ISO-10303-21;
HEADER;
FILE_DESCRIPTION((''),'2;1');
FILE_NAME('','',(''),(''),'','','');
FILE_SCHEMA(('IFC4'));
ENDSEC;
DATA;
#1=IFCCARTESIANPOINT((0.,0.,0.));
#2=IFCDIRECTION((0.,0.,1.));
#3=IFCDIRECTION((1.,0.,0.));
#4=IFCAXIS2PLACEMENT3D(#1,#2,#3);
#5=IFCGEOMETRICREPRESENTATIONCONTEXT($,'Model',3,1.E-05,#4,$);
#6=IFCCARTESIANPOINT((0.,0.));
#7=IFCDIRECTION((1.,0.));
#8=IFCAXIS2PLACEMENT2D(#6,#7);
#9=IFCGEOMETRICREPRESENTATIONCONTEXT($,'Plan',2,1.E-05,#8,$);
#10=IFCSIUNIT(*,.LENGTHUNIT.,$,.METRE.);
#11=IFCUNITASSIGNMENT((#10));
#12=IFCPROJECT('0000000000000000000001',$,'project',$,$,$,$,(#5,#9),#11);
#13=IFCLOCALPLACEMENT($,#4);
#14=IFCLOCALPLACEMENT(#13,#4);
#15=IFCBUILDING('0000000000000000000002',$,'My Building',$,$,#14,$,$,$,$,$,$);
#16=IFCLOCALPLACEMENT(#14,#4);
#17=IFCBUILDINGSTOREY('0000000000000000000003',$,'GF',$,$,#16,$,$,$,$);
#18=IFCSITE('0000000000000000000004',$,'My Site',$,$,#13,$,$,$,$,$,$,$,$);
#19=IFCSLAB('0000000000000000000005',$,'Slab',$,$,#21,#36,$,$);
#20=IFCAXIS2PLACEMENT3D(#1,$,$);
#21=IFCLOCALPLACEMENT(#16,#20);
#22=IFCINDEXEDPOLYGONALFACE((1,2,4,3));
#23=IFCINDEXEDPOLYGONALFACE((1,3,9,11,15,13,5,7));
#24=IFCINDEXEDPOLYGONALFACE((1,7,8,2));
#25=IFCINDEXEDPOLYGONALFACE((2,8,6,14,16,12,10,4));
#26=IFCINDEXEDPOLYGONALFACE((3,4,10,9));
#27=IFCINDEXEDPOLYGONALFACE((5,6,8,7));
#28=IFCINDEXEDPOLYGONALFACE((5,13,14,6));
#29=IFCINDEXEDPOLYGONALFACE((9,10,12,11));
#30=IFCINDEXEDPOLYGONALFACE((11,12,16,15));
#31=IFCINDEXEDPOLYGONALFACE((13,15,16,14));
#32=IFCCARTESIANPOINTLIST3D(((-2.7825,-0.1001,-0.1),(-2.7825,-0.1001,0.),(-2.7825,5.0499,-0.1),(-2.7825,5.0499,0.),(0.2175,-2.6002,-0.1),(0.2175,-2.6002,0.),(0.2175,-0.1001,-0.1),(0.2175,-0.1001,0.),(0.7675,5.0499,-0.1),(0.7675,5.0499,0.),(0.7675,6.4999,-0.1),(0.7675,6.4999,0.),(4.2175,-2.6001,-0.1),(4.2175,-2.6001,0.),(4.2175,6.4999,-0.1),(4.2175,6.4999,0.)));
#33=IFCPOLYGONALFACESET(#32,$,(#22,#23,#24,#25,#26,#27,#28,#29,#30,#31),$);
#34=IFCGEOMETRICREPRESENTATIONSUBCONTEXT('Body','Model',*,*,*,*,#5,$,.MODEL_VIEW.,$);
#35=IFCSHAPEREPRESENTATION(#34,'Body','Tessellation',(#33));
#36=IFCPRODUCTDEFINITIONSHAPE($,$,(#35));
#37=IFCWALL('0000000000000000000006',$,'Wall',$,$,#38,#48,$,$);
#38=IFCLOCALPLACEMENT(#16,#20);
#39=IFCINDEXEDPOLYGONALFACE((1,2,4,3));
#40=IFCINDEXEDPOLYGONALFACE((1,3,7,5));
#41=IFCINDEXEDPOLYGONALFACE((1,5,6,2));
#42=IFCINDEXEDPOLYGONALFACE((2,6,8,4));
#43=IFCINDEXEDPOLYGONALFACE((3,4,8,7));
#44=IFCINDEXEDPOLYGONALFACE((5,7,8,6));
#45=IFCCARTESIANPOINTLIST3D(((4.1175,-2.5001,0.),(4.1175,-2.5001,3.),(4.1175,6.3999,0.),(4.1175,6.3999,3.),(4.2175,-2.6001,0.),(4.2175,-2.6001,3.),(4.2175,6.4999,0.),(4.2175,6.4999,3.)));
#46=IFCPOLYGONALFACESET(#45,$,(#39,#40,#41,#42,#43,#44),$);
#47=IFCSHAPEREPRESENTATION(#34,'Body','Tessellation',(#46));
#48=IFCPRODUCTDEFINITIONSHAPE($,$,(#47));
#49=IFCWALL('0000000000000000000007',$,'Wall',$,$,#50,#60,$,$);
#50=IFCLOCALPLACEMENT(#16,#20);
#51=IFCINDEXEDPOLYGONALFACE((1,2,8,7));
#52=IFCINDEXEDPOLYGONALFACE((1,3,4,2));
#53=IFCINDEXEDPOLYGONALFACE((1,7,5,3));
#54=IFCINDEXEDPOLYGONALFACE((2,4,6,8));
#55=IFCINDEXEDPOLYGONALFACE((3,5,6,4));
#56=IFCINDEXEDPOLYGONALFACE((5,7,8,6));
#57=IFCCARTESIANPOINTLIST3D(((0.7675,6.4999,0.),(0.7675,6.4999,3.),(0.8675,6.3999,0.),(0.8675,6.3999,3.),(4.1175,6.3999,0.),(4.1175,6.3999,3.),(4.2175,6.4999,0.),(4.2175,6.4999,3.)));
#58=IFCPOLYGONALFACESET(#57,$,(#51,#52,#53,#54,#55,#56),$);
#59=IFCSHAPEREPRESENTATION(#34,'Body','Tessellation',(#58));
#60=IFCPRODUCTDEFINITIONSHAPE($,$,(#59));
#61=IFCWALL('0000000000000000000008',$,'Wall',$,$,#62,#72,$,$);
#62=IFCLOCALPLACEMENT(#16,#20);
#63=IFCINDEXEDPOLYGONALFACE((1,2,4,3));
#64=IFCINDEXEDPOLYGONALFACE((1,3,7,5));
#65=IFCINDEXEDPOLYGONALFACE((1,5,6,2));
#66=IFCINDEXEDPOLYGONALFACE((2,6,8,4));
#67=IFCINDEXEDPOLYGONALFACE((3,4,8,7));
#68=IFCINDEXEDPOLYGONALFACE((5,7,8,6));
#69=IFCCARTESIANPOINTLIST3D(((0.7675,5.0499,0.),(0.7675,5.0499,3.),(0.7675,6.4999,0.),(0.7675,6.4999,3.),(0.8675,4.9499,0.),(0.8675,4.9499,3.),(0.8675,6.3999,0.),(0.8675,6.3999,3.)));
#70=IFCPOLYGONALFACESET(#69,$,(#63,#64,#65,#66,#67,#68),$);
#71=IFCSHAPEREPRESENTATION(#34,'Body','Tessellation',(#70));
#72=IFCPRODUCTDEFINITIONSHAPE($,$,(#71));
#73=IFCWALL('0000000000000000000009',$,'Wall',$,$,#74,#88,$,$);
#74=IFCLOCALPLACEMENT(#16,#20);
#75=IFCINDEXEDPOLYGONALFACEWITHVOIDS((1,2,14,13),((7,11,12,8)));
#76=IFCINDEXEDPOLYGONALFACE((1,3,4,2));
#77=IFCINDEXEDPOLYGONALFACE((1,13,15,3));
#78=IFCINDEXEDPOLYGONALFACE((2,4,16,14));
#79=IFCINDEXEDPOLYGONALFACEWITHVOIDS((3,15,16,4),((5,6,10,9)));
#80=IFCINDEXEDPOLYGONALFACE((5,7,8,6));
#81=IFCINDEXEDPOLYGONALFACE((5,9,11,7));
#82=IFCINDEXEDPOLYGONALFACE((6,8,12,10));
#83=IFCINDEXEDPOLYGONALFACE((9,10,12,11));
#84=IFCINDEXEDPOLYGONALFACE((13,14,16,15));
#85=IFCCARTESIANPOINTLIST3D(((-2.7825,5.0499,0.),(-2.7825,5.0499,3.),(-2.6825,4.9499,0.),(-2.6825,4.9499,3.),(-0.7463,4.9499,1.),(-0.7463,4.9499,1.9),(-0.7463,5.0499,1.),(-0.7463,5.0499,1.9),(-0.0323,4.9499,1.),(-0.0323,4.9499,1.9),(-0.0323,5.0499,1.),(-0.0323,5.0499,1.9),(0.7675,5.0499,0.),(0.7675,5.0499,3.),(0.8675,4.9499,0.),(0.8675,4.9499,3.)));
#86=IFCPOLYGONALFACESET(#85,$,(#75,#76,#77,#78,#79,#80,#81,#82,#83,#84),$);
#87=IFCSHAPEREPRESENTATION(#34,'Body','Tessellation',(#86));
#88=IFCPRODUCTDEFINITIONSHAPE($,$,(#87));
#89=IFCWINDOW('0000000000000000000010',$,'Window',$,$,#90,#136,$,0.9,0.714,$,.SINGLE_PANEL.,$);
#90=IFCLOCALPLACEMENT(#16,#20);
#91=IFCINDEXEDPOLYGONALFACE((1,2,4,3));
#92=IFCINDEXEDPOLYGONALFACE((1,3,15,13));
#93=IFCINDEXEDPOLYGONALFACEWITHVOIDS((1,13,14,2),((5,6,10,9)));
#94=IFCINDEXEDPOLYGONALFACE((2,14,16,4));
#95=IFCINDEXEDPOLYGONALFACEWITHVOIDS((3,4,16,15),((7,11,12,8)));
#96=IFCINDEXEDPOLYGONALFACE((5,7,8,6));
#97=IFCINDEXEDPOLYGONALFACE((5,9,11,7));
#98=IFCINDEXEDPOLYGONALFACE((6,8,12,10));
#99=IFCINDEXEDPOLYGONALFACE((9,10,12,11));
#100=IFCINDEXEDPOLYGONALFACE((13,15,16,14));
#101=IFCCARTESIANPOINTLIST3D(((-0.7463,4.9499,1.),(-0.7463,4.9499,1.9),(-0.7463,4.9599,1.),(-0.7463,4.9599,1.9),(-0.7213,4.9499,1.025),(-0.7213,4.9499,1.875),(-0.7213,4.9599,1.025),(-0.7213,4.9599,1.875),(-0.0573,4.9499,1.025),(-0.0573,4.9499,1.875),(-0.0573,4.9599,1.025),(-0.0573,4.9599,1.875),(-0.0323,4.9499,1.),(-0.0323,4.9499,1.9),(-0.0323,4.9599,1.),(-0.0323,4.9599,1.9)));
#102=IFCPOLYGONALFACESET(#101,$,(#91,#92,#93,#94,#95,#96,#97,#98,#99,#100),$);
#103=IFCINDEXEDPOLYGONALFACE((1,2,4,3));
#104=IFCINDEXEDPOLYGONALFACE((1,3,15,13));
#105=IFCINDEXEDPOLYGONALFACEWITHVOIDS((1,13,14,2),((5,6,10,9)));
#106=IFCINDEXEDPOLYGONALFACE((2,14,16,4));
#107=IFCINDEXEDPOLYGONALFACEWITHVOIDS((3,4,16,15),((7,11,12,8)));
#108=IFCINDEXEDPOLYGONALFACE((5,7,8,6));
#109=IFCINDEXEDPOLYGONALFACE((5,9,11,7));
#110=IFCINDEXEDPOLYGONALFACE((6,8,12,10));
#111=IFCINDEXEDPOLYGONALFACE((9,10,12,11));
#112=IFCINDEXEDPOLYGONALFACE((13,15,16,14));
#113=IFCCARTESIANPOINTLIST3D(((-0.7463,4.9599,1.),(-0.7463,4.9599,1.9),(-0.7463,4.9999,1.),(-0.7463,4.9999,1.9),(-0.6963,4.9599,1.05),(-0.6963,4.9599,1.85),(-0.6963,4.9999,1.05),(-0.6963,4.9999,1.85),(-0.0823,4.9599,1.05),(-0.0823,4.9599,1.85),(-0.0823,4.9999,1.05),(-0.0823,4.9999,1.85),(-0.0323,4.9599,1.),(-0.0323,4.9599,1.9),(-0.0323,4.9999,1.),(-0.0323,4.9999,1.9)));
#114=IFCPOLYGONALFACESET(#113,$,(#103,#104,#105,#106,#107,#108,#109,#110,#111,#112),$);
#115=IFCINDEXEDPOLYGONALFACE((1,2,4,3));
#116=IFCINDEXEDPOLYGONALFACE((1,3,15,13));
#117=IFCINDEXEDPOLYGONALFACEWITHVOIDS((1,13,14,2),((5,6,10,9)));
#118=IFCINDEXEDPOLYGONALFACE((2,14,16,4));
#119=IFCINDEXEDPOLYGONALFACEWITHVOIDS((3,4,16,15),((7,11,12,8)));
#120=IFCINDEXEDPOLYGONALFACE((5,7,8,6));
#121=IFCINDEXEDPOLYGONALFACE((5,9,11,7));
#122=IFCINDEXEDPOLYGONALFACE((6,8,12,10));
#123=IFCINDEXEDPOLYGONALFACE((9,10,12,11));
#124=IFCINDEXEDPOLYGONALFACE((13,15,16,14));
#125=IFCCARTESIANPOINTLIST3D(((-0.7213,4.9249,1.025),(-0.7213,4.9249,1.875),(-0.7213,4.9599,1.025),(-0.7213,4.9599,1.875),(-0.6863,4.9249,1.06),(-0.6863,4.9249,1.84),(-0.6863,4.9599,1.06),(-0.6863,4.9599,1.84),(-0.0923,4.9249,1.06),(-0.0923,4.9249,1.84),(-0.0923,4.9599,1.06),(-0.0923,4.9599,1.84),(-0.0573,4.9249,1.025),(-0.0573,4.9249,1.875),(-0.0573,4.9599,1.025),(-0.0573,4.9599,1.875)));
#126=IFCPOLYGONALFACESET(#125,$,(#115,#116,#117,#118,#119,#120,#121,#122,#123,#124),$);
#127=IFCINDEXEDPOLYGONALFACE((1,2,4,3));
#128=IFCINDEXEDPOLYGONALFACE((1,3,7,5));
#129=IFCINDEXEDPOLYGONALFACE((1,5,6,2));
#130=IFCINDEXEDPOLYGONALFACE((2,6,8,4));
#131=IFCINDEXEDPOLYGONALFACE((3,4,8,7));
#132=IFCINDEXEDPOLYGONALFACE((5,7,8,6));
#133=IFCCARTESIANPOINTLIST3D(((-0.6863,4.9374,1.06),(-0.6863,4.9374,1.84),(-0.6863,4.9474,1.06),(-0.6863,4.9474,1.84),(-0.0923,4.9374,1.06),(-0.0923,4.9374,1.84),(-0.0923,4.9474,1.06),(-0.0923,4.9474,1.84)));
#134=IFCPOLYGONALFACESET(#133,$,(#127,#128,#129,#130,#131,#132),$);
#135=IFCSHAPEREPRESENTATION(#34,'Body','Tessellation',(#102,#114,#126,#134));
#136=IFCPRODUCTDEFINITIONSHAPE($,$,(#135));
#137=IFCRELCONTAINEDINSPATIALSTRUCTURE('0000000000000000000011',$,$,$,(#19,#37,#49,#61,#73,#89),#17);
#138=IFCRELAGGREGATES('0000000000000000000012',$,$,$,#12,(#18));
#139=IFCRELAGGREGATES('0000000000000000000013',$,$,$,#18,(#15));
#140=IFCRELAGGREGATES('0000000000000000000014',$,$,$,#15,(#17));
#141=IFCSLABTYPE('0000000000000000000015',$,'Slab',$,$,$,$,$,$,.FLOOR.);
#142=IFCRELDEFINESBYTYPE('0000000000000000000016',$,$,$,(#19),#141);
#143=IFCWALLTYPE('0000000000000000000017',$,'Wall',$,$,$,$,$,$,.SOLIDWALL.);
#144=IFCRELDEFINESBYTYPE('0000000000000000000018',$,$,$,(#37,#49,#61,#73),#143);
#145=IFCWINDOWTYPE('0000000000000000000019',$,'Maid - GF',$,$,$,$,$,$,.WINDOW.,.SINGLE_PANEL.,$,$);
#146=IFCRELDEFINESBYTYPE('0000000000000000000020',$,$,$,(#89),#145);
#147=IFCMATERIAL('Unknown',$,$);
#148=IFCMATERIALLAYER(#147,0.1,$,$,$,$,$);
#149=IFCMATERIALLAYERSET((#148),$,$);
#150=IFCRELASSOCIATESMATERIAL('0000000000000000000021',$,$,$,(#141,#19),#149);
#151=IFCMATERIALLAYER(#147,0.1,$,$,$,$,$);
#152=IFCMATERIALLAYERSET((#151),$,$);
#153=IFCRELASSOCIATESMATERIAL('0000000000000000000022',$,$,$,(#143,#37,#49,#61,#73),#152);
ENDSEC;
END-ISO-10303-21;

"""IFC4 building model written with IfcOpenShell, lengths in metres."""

from ifc_helpers import new_model, entity, si_unit, frame, origin_with_axes, origin_2d_with_axis, place, context, subcontext, project, spatial, line, indexed_curve, outline, extrude, shape, source, transform, mapped, material, layer, layer_set, layer_usage, type_object, type_shapes, element, fill, save


model = new_model("IFC4")

# Units and contexts
model_context = context("Model", 3, precision=1e-05, world=origin_with_axes())
plan_context = context("Plan", 2, precision=1e-05, world=origin_2d_with_axis())
body_context_1 = subcontext(model_context, "Body", "Model", "MODEL_VIEW")
body_context_2 = subcontext(plan_context, "Body", "Plan", "PLAN_VIEW")
ifc_project = project(units=[si_unit("LENGTHUNIT", "METRE")], contexts=[model_context, plan_context])

# Site, building, storey
site_placement = place(None, origin_with_axes())
site = spatial("IfcSite", under=ifc_project, at=site_placement, Name="My Site")
building_placement = place(site_placement, origin_with_axes())
building = spatial("IfcBuilding", under=site, at=building_placement, Name="My Building")
storey_placement = place(building_placement, origin_with_axes())
storey = spatial("IfcBuildingStorey", under=building, at=storey_placement, Name="GF")

# Slab
ifc_material = material(Name="Unknown")
ifc_layer_1 = layer(ifc_material, 0.1)
ifc_layer_set_1 = layer_set([ifc_layer_1])
ifc_layer_usage_1 = layer_usage(ifc_layer_set_1, "AXIS3", "POSITIVE", -0.1)
slab_type = type_object("IfcSlabType", Name="Slab", PredefinedType="FLOOR", material=ifc_layer_set_1)
slab_placement = place(storey_placement, frame((4.2175, -2.6001, 0.0), z_axis=(0.0, 0.0, 1.0), x_axis=(1.0, 0.0, 0.0)))
element("IfcSlab", 1, at=slab_placement, inside=storey, type_object=slab_type, material=ifc_layer_usage_1, Name="Slab", context=body_context_1, shape_type="SweptSolid", body=[
    extrude(outline(indexed_curve([(0.0, 0.0), (0.0, 9.1), (-3.45, 9.1), (-3.45, 7.6499), (-7.0, 7.6499), (-7.0, 2.5), (-4.0, 2.5), (-4.0, -0.0001), (0.0, 0.0)])), frame((0.0, 0.0, -0.1), z_axis=(0.0, 0.0, 1.0), x_axis=(1.0, 0.0, 0.0)), (0.0, 0.0, 1.0), 0.1),
])

# Shared definitions
ifc_layer_2 = layer(ifc_material, 0.1)
ifc_layer_set_2 = layer_set([ifc_layer_2])
wall_type = type_object("IfcWallType", Name="Wall", PredefinedType="SOLIDWALL", material=ifc_layer_set_2)

# Walls
ifc_layer_usage_2 = layer_usage(ifc_layer_set_2, "AXIS2", "POSITIVE", 0.0)
wall_1_placement = place(storey_placement, frame((4.2175, -2.6001, 0.0), z_axis=(0.0, 0.0, 1.0), x_axis=(0.0, 1.0, 0.0)))
element("IfcWall", 2, at=wall_1_placement, inside=storey, type_object=wall_type, material=ifc_layer_usage_2, Name="Wall", context=body_context_1, shape_type="SweptSolid", body=[
    extrude(outline(indexed_curve([(0.0, 0.0), (0.1, 0.1), (9.0, 0.1), (9.1, 0.0)], segments=[line(1, 2, 3, 4, 1)])), origin_with_axes(), (0.0, 0.0, 1.0), 3.0),
])
ifc_layer_usage_3 = layer_usage(ifc_layer_set_2, "AXIS2", "POSITIVE", 0.0)
wall_2_placement = place(storey_placement, frame((4.2175, 6.4999, 0.0), z_axis=(0.0, 0.0, 1.0), x_axis=(-1.0, 0.0, 0.0)))
element("IfcWall", 3, at=wall_2_placement, inside=storey, type_object=wall_type, material=ifc_layer_usage_3, Name="Wall", context=body_context_1, shape_type="SweptSolid", body=[
    extrude(outline(indexed_curve([(0.0, 0.0), (0.1, 0.1), (3.35, 0.1), (3.45, 0.0)], segments=[line(1, 2, 3, 4, 1)])), origin_with_axes(), (0.0, 0.0, 1.0), 3.0),
])
ifc_layer_usage_4 = layer_usage(ifc_layer_set_2, "AXIS2", "POSITIVE", 0.0)
wall_3_placement = place(storey_placement, frame((0.7675, 6.4999, 0.0), z_axis=(0.0, 0.0, 1.0), x_axis=(0.0, -1.0, 0.0)))
element("IfcWall", 4, at=wall_3_placement, inside=storey, type_object=wall_type, material=ifc_layer_usage_4, Name="Wall", context=body_context_1, shape_type="SweptSolid", body=[
    extrude(outline(indexed_curve([(0.0, 0.0), (0.1, 0.1), (1.55, 0.1), (1.45, 0.0)], segments=[line(1, 2, 3, 4, 1)])), origin_with_axes(), (0.0, 0.0, 1.0), 3.0),
])

# Wall, opening, window
ifc_layer_usage_5 = layer_usage(ifc_layer_set_2, "AXIS2", "POSITIVE", 0.0)
wall_4_placement = place(storey_placement, frame((0.7675, 5.0499, 0.0), z_axis=(0.0, 0.0, 1.0), x_axis=(-1.0, 0.0, 0.0)))
wall_4 = element("IfcWall", 5, at=wall_4_placement, inside=storey, type_object=wall_type, material=ifc_layer_usage_5, Name="Wall", context=body_context_1, shape_type="SweptSolid", body=[
    extrude(outline(indexed_curve([(0.0, 0.0), (-0.1, 0.1), (3.45, 0.1), (3.55, 0.0)], segments=[line(1, 2, 3, 4, 1)])), origin_with_axes(), (0.0, 0.0, 1.0), 3.0),
])
shared_shape_1 = source(origin_with_axes(), body_context_1, "Body", "SweptSolid", [
    extrude(outline(indexed_curve([(0.0, 0.0), (0.714, 0.0), (0.714, 0.9), (0.0, 0.9)], segments=[line(1, 2, 3, 4, 1)])), frame((0.0, -0.6, 0.0), z_axis=(0.0, -1.0, 0.0), x_axis=(1.0, 0.0, 0.0)), (0.0, 0.0, -1.0), 1.2),
])
opening_1_placement = place(wall_4_placement, frame((0.7998, 0.0, 1.0), z_axis=(0.0, 0.0, 1.0), x_axis=(1.0, 0.0, 0.0)))
opening_1 = element("IfcOpeningElement", 6, at=opening_1_placement, cuts=wall_4, PredefinedType="OPENING", context=body_context_1, shape_type="MappedRepresentation", body=[
    mapped(shared_shape_1, transform((0.0, 0.0, 0.0), x_axis=(1.0, 0.0, 0.0), y_axis=(0.0, 1.0, 0.0), z_axis=(0.0, 0.0, 1.0), scale=1.0)),
])
window_type_1 = type_object("IfcWindowType", Name="Maid - GF", PartitioningType="SINGLE_PANEL", PredefinedType="WINDOW")
shared_shape_2 = source(origin_with_axes(), body_context_1, "Body", "SweptSolid", [
    extrude(outline(indexed_curve([(0.0, 0.0), (0.714, 0.0), (0.714, 0.9), (0.0, 0.9)], segments=[line(1, 2, 3, 4, 1)]), holes=[indexed_curve([(0.025, 0.025), (0.689, 0.025), (0.689, 0.875), (0.025, 0.875)], segments=[line(1, 2, 3, 4, 1)])]), frame((0.0, 0.09, 0.0), z_axis=(0.0, -1.0, 0.0), x_axis=(1.0, 0.0, 0.0)), (0.0, 0.0, -1.0), 0.01),
    extrude(outline(indexed_curve([(0.0, 0.0), (0.714, 0.0), (0.714, 0.9), (0.0, 0.9)], segments=[line(1, 2, 3, 4, 1)]), holes=[indexed_curve([(0.05, 0.05), (0.664, 0.05), (0.664, 0.85), (0.05, 0.85)], segments=[line(1, 2, 3, 4, 1)])]), frame((0.0, 0.05, 0.0), z_axis=(0.0, -1.0, 0.0), x_axis=(1.0, 0.0, 0.0)), (0.0, 0.0, -1.0), 0.04),
    extrude(outline(indexed_curve([(0.0, 0.0), (0.664, 0.0), (0.664, 0.85), (0.0, 0.85)], segments=[line(1, 2, 3, 4, 1)]), holes=[indexed_curve([(0.035, 0.035), (0.629, 0.035), (0.629, 0.815), (0.035, 0.815)], segments=[line(1, 2, 3, 4, 1)])]), frame((0.025, 0.09, 0.025), z_axis=(0.0, -1.0, 0.0), x_axis=(1.0, 0.0, 0.0)), (0.0, 0.0, -1.0), 0.035),
    extrude(outline(indexed_curve([(0.035, 0.035), (0.629, 0.035), (0.629, 0.815), (0.035, 0.815)], segments=[line(1, 2, 3, 4, 1)])), frame((0.025, 0.1025, 0.025), z_axis=(0.0, -1.0, 0.0), x_axis=(1.0, 0.0, 0.0)), (0.0, 0.0, -1.0), 0.01),
])
shared_shape_3 = source(origin_with_axes(), body_context_2, "Body", "Curve2D", [
    entity("IfcIndexedPolyCurve", entity("IfcCartesianPointList2D", [[0.05, 0.05], [0.664, 0.05]])),
    entity("IfcIndexedPolyCurve", entity("IfcCartesianPointList2D", [[0.0, 0.1], [0.025, 0.1], [0.025, 0.09], [0.05, 0.09], [0.05, 0.05], [0.0, 0.05]]), [entity("IfcLineIndex", [1, 2, 3, 4, 5, 6, 1])]),
    entity("IfcIndexedPolyCurve", entity("IfcCartesianPointList2D", [[0.714, 0.1], [0.689, 0.1], [0.689, 0.09], [0.664, 0.09], [0.664, 0.05], [0.714, 0.05]]), [entity("IfcLineIndex", [1, 2, 3, 4, 5, 6, 1])]),
    entity("IfcIndexedPolyCurve", entity("IfcCartesianPointList2D", [[0.025, 0.09], [0.06, 0.09], [0.06, 0.125], [0.025, 0.125]]), [entity("IfcLineIndex", [1, 2, 3, 4, 1])]),
    entity("IfcIndexedPolyCurve", entity("IfcCartesianPointList2D", [[0.689, 0.09], [0.654, 0.09], [0.654, 0.125], [0.689, 0.125]]), [entity("IfcLineIndex", [1, 2, 3, 4, 1])]),
    entity("IfcIndexedPolyCurve", entity("IfcCartesianPointList2D", [[0.06, 0.09], [0.654, 0.09]])),
    entity("IfcIndexedPolyCurve", entity("IfcCartesianPointList2D", [[0.06, 0.125], [0.654, 0.125]])),
    entity("IfcIndexedPolyCurve", entity("IfcCartesianPointList2D", [[0.06, 0.1075], [0.654, 0.1075]])),
])
type_shapes(window_type_1, [shared_shape_2, shared_shape_3])
window_1_placement = place(opening_1_placement, frame((0.0, 0.0, 0.0), z_axis=(0.0, 0.0, 1.0), x_axis=(1.0, 0.0, 0.0)))
window_1 = element("IfcWindow", 7, at=window_1_placement, inside=storey, type_object=window_type_1, Name="Window", OverallHeight=0.9, OverallWidth=0.714, PartitioningType="SINGLE_PANEL", shapes=[
    shape(body_context_1, "Body", "MappedRepresentation", [mapped(shared_shape_2, transform((0.0, 0.0, 0.0), x_axis=(1.0, 0.0, 0.0), y_axis=(0.0, 1.0, 0.0), z_axis=(0.0, 0.0, 1.0), scale=1.0))]),
    shape(body_context_2, "Body", "MappedRepresentation", [mapped(shared_shape_3, transform((0.0, 0.0, 0.0), x_axis=(1.0, 0.0, 0.0), y_axis=(0.0, 1.0, 0.0), z_axis=(0.0, 0.0, 1.0), scale=1.0))]),
])
fill(opening_1, window_1)

save(model, "model.ifc")
